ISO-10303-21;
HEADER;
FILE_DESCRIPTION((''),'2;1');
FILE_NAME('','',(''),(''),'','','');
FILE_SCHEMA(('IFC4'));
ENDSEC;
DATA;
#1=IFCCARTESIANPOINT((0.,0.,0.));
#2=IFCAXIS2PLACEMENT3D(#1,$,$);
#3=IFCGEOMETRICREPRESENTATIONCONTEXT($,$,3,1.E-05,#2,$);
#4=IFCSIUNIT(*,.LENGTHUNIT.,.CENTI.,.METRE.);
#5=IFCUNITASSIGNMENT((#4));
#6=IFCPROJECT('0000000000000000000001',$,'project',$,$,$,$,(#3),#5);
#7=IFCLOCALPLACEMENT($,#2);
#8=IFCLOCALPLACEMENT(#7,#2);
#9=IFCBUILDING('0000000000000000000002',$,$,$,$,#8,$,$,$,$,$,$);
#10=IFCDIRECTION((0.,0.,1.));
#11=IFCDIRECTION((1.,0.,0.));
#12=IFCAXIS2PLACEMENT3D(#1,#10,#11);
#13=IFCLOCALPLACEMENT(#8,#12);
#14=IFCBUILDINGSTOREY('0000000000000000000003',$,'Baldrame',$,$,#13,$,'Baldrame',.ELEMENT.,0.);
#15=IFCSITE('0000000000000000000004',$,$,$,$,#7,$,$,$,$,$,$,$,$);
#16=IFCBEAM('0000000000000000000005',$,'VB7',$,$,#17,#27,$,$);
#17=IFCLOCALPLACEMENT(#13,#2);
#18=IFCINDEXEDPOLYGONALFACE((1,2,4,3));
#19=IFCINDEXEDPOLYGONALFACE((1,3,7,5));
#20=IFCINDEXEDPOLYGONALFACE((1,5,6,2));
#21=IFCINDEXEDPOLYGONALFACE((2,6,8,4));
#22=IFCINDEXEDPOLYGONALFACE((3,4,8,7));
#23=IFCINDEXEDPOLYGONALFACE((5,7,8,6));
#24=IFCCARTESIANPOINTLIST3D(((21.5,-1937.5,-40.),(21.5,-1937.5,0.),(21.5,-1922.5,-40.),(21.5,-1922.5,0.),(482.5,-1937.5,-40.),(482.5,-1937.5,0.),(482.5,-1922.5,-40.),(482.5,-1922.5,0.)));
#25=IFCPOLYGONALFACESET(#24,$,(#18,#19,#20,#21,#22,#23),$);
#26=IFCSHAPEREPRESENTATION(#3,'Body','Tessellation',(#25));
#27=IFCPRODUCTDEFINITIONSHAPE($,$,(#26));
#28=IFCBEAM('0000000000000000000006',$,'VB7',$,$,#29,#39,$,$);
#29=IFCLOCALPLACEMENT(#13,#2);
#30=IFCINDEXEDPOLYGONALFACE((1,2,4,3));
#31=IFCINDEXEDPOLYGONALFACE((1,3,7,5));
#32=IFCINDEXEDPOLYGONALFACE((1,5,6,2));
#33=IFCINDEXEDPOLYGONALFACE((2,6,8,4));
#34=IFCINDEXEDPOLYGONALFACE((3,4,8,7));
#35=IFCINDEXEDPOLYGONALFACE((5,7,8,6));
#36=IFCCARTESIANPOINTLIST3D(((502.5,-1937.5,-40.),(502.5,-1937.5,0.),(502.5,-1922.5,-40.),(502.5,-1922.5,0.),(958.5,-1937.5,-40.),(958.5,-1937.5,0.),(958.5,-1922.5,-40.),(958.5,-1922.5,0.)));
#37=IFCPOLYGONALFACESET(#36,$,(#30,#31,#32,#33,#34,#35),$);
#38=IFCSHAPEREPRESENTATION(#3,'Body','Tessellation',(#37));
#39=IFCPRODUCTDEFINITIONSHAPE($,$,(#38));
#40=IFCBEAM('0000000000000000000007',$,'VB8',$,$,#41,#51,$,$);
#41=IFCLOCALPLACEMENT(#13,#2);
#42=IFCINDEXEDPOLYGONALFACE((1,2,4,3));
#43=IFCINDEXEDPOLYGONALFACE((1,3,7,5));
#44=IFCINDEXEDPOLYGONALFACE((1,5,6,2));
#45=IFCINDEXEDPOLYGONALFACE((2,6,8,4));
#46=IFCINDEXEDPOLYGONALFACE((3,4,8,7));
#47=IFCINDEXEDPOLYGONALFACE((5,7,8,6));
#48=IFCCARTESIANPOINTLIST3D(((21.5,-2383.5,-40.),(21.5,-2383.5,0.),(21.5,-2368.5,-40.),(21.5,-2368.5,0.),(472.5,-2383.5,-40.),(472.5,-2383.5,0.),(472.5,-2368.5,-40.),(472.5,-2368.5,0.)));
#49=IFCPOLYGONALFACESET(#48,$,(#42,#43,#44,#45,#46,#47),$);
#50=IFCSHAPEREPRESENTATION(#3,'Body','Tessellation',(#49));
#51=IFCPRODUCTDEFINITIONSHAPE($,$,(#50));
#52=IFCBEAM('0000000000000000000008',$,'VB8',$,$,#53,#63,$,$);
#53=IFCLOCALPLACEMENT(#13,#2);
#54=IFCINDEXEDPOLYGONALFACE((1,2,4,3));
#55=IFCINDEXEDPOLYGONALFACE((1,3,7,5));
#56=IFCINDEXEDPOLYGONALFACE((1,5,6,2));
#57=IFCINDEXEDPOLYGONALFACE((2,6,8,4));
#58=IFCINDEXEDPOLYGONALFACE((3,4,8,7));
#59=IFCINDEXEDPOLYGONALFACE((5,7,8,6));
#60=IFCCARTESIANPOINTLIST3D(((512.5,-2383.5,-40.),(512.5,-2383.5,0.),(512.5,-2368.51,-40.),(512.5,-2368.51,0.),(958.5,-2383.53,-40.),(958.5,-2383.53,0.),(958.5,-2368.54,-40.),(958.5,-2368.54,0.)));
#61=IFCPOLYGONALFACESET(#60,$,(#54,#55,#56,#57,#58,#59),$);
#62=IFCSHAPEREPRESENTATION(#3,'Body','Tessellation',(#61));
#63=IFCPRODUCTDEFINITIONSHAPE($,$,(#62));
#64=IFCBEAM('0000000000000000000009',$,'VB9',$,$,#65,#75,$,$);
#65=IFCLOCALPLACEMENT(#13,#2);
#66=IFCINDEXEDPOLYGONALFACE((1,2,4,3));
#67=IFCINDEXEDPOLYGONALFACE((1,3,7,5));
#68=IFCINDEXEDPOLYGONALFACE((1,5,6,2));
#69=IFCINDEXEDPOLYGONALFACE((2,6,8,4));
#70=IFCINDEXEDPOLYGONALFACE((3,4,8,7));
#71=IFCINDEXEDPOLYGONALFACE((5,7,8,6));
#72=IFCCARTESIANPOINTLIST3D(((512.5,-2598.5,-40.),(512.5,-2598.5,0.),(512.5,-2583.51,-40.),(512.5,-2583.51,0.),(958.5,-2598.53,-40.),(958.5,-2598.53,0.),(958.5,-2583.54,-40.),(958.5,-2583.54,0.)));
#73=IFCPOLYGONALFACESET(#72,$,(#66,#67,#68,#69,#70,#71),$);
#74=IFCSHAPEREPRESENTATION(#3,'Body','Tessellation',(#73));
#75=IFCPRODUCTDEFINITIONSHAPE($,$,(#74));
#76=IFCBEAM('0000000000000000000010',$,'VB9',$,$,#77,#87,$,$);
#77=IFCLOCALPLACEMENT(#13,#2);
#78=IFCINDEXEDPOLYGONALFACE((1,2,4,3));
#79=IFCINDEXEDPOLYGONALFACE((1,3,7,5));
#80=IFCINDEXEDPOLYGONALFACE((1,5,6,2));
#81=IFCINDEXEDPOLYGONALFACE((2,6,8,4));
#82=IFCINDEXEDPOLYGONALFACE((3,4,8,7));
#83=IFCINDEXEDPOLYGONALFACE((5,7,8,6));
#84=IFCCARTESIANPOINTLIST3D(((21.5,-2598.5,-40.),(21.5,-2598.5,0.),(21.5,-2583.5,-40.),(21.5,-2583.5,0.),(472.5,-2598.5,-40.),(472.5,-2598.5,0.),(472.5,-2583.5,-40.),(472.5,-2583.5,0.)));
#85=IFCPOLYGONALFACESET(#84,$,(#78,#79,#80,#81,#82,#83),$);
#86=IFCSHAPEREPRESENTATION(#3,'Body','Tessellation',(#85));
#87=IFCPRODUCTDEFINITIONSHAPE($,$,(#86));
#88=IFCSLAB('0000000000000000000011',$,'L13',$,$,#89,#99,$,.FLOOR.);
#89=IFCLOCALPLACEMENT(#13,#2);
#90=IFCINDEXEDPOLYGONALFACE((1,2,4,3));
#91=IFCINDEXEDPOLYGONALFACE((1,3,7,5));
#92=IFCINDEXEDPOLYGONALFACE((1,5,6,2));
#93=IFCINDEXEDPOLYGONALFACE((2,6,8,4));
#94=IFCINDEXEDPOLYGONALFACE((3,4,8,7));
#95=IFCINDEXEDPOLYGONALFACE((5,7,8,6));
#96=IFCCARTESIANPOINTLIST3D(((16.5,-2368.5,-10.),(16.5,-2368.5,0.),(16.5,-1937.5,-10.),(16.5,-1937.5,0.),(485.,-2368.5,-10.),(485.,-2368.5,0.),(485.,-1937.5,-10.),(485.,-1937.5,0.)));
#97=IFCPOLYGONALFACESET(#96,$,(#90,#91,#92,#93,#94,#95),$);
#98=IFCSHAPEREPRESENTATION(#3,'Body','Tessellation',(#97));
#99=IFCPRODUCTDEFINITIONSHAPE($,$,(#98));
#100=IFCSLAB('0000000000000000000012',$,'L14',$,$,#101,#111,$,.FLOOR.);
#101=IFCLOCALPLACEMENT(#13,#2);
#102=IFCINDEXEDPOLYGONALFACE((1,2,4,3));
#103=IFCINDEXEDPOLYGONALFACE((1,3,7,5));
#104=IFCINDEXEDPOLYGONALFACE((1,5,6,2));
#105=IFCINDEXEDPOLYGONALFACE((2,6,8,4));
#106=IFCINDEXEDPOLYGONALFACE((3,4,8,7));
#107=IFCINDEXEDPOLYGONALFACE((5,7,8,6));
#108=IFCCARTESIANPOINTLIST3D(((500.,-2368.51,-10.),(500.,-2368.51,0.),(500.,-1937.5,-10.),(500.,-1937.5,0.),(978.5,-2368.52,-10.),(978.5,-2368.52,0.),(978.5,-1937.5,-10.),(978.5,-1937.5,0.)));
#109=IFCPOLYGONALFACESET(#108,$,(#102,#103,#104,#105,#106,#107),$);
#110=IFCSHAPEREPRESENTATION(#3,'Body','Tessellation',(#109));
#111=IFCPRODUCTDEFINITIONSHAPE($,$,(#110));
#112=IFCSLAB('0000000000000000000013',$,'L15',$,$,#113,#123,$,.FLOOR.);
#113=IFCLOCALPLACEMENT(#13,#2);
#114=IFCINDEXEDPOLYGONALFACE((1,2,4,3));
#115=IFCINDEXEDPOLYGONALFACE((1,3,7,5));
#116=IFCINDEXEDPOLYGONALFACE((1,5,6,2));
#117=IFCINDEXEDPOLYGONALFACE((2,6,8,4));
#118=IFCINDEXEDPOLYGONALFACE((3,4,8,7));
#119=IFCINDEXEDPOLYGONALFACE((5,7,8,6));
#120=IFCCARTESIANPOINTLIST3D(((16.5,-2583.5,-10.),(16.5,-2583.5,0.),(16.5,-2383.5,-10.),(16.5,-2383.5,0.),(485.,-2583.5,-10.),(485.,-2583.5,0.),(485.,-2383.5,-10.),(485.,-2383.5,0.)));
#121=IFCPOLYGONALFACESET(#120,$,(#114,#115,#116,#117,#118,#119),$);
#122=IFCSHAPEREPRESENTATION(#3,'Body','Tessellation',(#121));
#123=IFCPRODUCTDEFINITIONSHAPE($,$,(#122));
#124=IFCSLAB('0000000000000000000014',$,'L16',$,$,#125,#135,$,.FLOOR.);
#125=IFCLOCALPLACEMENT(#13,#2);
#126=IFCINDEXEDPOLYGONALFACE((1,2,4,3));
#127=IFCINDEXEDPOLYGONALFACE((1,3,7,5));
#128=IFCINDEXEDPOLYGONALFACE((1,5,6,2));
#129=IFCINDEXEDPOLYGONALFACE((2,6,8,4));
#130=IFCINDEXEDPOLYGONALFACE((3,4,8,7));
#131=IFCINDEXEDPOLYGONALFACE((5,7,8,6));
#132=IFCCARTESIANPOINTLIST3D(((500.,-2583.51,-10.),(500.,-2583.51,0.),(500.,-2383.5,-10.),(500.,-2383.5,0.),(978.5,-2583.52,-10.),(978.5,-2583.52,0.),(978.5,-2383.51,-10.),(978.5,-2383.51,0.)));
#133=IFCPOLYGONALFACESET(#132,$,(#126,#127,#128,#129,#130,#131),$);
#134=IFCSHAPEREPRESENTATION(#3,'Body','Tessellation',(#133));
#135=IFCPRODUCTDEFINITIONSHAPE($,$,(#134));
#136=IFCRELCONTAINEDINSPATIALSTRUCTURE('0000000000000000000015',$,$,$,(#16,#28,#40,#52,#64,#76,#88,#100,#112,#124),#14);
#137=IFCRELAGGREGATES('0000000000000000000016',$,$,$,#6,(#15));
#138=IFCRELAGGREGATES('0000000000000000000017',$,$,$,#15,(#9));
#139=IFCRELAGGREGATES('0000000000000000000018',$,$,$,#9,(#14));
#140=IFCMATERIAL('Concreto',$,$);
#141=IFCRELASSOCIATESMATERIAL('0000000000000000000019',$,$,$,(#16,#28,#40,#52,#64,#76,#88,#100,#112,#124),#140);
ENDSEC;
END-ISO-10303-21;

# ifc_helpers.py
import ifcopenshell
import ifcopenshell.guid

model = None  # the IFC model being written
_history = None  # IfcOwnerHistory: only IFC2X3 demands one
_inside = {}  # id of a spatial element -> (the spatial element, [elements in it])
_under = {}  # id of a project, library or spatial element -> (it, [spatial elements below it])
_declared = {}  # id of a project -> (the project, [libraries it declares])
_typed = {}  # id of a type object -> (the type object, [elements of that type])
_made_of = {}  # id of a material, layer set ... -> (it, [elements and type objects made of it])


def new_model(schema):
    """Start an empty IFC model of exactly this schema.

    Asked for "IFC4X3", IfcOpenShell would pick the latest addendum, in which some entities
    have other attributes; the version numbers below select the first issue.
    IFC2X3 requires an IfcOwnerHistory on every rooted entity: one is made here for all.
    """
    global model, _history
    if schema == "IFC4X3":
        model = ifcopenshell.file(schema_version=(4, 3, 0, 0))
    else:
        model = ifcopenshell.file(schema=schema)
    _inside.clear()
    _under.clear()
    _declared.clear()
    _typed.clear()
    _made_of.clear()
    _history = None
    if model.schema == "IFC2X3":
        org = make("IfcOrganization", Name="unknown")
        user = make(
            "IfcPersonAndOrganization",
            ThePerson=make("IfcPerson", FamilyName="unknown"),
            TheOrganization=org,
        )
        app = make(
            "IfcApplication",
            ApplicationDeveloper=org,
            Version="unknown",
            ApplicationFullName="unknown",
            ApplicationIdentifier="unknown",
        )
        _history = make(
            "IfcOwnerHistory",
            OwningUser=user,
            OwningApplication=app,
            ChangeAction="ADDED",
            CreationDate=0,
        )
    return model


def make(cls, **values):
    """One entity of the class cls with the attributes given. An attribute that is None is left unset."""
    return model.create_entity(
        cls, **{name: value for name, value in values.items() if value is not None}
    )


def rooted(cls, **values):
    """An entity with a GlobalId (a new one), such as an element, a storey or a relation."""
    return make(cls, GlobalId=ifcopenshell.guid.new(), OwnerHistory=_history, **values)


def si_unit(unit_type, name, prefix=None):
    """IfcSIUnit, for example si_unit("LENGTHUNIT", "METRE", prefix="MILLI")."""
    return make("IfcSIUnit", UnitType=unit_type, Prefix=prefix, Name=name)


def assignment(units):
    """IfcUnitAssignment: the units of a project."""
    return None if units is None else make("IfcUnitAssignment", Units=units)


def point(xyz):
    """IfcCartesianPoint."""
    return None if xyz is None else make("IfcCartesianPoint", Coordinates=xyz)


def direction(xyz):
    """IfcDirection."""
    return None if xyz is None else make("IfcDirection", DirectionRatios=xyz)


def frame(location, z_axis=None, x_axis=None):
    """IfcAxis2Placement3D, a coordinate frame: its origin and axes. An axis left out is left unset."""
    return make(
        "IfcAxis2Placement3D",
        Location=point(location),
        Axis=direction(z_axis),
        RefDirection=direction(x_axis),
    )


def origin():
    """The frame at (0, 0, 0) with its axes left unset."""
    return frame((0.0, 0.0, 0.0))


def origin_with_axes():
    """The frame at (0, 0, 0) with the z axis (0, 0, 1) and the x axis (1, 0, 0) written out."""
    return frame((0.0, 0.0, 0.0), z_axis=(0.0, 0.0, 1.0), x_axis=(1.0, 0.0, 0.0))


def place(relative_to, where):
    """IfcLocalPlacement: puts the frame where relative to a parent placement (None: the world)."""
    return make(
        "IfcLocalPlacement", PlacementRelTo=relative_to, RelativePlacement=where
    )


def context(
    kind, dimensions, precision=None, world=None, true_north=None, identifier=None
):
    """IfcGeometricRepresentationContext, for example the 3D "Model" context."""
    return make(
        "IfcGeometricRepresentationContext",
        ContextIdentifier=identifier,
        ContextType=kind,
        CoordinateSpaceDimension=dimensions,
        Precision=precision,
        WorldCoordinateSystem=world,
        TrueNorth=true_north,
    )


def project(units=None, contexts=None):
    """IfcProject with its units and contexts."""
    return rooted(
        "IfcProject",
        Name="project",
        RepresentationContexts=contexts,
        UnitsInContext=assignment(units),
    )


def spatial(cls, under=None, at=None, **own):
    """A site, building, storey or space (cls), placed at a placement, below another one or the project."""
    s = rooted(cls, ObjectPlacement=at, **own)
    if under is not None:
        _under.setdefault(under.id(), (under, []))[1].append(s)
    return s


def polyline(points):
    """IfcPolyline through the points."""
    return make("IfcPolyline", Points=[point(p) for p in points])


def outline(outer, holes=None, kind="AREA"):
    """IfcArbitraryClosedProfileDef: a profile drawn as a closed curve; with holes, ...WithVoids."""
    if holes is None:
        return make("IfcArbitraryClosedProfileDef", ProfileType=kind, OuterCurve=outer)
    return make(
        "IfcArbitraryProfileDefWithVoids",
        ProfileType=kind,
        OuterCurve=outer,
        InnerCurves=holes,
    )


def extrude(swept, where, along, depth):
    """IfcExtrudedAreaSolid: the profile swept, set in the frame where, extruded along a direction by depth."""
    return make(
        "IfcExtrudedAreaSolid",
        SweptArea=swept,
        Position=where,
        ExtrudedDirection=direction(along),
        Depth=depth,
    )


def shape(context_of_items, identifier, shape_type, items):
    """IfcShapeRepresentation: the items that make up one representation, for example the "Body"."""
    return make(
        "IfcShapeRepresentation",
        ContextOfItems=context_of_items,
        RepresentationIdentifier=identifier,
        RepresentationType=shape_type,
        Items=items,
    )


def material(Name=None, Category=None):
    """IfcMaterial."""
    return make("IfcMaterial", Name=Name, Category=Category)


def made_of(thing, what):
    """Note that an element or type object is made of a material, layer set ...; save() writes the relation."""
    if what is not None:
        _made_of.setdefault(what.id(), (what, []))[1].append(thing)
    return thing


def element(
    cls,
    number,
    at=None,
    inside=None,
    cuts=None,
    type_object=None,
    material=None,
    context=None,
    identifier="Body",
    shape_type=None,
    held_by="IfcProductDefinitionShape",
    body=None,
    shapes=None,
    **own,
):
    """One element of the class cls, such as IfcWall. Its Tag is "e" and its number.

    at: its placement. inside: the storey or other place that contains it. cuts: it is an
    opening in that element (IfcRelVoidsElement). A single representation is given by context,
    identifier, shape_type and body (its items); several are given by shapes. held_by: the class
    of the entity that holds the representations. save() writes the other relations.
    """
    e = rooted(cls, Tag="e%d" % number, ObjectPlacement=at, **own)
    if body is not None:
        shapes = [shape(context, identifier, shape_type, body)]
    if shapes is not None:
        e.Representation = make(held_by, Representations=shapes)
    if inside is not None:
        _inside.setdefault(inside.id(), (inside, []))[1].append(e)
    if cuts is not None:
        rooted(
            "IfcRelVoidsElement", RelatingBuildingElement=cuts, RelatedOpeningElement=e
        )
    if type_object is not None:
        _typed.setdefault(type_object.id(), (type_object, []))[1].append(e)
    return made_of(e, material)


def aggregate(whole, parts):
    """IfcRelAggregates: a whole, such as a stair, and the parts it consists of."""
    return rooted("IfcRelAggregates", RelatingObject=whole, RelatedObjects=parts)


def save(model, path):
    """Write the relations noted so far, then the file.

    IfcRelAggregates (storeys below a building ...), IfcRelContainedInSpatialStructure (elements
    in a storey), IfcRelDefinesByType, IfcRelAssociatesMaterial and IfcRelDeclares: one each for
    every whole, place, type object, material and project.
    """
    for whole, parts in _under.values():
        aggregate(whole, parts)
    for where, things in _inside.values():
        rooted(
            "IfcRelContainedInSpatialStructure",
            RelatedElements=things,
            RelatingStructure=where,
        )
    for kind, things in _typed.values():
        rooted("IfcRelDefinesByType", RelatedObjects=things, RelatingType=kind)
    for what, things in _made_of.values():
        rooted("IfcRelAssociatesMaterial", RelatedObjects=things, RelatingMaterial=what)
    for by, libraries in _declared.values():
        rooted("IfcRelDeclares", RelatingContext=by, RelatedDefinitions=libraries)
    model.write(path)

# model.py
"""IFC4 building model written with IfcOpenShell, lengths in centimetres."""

from ifc_helpers import new_model, si_unit, frame, origin, origin_with_axes, place, context, project, spatial, polyline, outline, extrude, material, element, save


model = new_model("IFC4")

# Units and contexts
context_of_model = context(None, 3, precision=1e-05, world=origin())
ifc_project = project(units=[si_unit("LENGTHUNIT", "METRE", prefix="CENTI")], contexts=[context_of_model])

# Site, building, storey
site_placement = place(None, origin())
site = spatial("IfcSite", under=ifc_project, at=site_placement)
building_placement = place(site_placement, origin())
building = spatial("IfcBuilding", under=site, at=building_placement)
storey_placement = place(building_placement, origin_with_axes())
storey = spatial("IfcBuildingStorey", under=building, at=storey_placement, Name="Baldrame", LongName="Baldrame", CompositionType="ELEMENT", Elevation=0.0)

# Shared definitions
ifc_material = material(Name="Concreto")

# Beams
beam_1_placement = place(storey_placement, frame((252.0, -1930.0, 0.0), z_axis=(0.0, 0.0, 1.0), x_axis=(1.0, 0.0, 0.0)))
element("IfcBeam", 1, at=beam_1_placement, inside=storey, material=ifc_material, Name="VB7", context=context_of_model, shape_type="SolidModel", body=[
    extrude(outline(polyline([(-7.5, -20.0), (7.5, -20.0), (7.5, 20.0), (-7.5, 20.0), (-7.5, -20.0)])), frame((-230.5, 0.0, -20.0), z_axis=(1.0, 0.0, 0.0), x_axis=(0.0, -1.0, 0.0)), (0.0, 0.0, 1.0), 461.0),
])
beam_2_placement = place(storey_placement, frame((730.5, -1930.0, 0.0), z_axis=(0.0, 0.0, 1.0), x_axis=(1.0, 0.0, 0.0)))
element("IfcBeam", 2, at=beam_2_placement, inside=storey, material=ifc_material, Name="VB7", context=context_of_model, shape_type="SolidModel", body=[
    extrude(outline(polyline([(-7.5, -20.0), (7.5, -20.0), (7.5, 20.0), (-7.5, 20.0), (-7.5, -20.0)])), frame((-228.0, 0.0, -20.0), z_axis=(1.0, 0.0, 0.0), x_axis=(0.0, -1.0, 0.0)), (0.0, 0.0, 1.0), 456.0),
])
beam_3_placement = place(storey_placement, frame((247.0, -2376.0, 0.0), z_axis=(0.0, 0.0, 1.0), x_axis=(1.0, 0.0, 0.0)))
element("IfcBeam", 3, at=beam_3_placement, inside=storey, material=ifc_material, Name="VB8", context=context_of_model, shape_type="SolidModel", body=[
    extrude(outline(polyline([(-7.5, -20.0), (7.5, -20.0), (7.5, 20.0), (-7.5, 20.0), (-7.5, -20.0)])), frame((-225.5, 0.0, -20.0), z_axis=(1.0, 0.0, 0.0), x_axis=(0.0, -1.0, 0.0)), (0.0, 0.0, 1.0), 451.0),
])
for number, where, z_axis, x_axis, name in (
    (4, (735.5, -2376.02, 0.0), (0.0, 0.0, 1.0), (1.0, 0.0, 0.0), "VB8"),
    (5, (735.5, -2591.02, 0.0), (0.0, 0.0, 1.0), (1.0, 0.0, 0.0), "VB9"),
):
    element("IfcBeam", number, at=place(storey_placement, frame(where, z_axis=z_axis, x_axis=x_axis)), inside=storey, material=ifc_material, Name=name, context=context_of_model, shape_type="SolidModel", body=[
        extrude(outline(polyline([(-7.5, -20.0), (7.5, -20.0), (7.5, 20.0), (-7.5, 20.0), (-7.5, -20.0)])), frame((-223.0, 0.01, -20.0), z_axis=(1.0, -0.000067, 0.0), x_axis=(-0.000067, -1.0, 0.0)), (0.0, 0.0, 1.0), 446.0),
    ])
beam_4_placement = place(storey_placement, frame((247.0, -2591.0, 0.0), z_axis=(0.0, 0.0, 1.0), x_axis=(1.0, 0.0, 0.0)))
element("IfcBeam", 6, at=beam_4_placement, inside=storey, material=ifc_material, Name="VB9", context=context_of_model, shape_type="SolidModel", body=[
    extrude(outline(polyline([(-7.5, -20.0), (7.5, -20.0), (7.5, 20.0), (-7.5, 20.0), (-7.5, -20.0)])), frame((-225.5, 0.0, -20.0), z_axis=(1.0, 0.0, 0.0), x_axis=(0.0, -1.0, 0.0)), (0.0, 0.0, 1.0), 451.0),
])

# Slabs
slab_1_placement = place(storey_placement, frame((250.75, -2153.0, 0.0), z_axis=(0.0, 0.0, 1.0), x_axis=(1.0, 0.0, 0.0)))
element("IfcSlab", 7, at=slab_1_placement, inside=storey, material=ifc_material, Name="L13", PredefinedType="FLOOR", context=context_of_model, shape_type="SolidModel", body=[
    extrude(outline(polyline([(234.25, 215.5), (-234.25, 215.5), (-234.25, -215.5), (234.25, -215.5), (234.25, 215.5), (234.25, 215.5)])), frame((0.0, 0.0, -10.0), z_axis=(0.0, 0.0, 1.0), x_axis=(1.0, 0.0, 0.0)), (0.0, 0.0, 1.0), 10.0),
])
slab_2_placement = place(storey_placement, frame((739.25, -2153.01, 0.0), z_axis=(0.0, 0.0, 1.0), x_axis=(1.0, 0.0, 0.0)))
element("IfcSlab", 8, at=slab_2_placement, inside=storey, material=ifc_material, Name="L14", PredefinedType="FLOOR", context=context_of_model, shape_type="SolidModel", body=[
    extrude(outline(polyline([(239.25, 215.52), (-239.25, 215.52), (-239.25, -215.5), (239.25, -215.51), (239.25, 215.52), (239.25, 215.52)])), frame((0.0, 0.0, -10.0), z_axis=(0.0, 0.0, 1.0), x_axis=(1.0, 0.0, 0.0)), (0.0, 0.0, 1.0), 10.0),
])
slab_3_placement = place(storey_placement, frame((250.75, -2483.5, 0.0), z_axis=(0.0, 0.0, 1.0), x_axis=(1.0, 0.0, 0.0)))
element("IfcSlab", 9, at=slab_3_placement, inside=storey, material=ifc_material, Name="L15", PredefinedType="FLOOR", context=context_of_model, shape_type="SolidModel", body=[
    extrude(outline(polyline([(234.25, 100.0), (-234.25, 100.0), (-234.25, -100.0), (234.25, -100.0), (234.25, 100.0), (234.25, 100.0)])), frame((0.0, 0.0, -10.0), z_axis=(0.0, 0.0, 1.0), x_axis=(1.0, 0.0, 0.0)), (0.0, 0.0, 1.0), 10.0),
])
slab_4_placement = place(storey_placement, frame((739.25, -2483.51, 0.0), z_axis=(0.0, 0.0, 1.0), x_axis=(1.0, 0.0, 0.0)))
element("IfcSlab", 10, at=slab_4_placement, inside=storey, material=ifc_material, Name="L16", PredefinedType="FLOOR", context=context_of_model, shape_type="SolidModel", body=[
    extrude(outline(polyline([(239.25, 100.0), (-239.25, 100.01), (-239.25, -100.0), (239.25, -100.01), (239.25, 100.0), (239.25, 100.0)])), frame((0.0, 0.0, -10.0), z_axis=(0.0, 0.0, 1.0), x_axis=(1.0, 0.0, 0.0)), (0.0, 0.0, 1.0), 10.0),
])

save(model, "model.ifc")
